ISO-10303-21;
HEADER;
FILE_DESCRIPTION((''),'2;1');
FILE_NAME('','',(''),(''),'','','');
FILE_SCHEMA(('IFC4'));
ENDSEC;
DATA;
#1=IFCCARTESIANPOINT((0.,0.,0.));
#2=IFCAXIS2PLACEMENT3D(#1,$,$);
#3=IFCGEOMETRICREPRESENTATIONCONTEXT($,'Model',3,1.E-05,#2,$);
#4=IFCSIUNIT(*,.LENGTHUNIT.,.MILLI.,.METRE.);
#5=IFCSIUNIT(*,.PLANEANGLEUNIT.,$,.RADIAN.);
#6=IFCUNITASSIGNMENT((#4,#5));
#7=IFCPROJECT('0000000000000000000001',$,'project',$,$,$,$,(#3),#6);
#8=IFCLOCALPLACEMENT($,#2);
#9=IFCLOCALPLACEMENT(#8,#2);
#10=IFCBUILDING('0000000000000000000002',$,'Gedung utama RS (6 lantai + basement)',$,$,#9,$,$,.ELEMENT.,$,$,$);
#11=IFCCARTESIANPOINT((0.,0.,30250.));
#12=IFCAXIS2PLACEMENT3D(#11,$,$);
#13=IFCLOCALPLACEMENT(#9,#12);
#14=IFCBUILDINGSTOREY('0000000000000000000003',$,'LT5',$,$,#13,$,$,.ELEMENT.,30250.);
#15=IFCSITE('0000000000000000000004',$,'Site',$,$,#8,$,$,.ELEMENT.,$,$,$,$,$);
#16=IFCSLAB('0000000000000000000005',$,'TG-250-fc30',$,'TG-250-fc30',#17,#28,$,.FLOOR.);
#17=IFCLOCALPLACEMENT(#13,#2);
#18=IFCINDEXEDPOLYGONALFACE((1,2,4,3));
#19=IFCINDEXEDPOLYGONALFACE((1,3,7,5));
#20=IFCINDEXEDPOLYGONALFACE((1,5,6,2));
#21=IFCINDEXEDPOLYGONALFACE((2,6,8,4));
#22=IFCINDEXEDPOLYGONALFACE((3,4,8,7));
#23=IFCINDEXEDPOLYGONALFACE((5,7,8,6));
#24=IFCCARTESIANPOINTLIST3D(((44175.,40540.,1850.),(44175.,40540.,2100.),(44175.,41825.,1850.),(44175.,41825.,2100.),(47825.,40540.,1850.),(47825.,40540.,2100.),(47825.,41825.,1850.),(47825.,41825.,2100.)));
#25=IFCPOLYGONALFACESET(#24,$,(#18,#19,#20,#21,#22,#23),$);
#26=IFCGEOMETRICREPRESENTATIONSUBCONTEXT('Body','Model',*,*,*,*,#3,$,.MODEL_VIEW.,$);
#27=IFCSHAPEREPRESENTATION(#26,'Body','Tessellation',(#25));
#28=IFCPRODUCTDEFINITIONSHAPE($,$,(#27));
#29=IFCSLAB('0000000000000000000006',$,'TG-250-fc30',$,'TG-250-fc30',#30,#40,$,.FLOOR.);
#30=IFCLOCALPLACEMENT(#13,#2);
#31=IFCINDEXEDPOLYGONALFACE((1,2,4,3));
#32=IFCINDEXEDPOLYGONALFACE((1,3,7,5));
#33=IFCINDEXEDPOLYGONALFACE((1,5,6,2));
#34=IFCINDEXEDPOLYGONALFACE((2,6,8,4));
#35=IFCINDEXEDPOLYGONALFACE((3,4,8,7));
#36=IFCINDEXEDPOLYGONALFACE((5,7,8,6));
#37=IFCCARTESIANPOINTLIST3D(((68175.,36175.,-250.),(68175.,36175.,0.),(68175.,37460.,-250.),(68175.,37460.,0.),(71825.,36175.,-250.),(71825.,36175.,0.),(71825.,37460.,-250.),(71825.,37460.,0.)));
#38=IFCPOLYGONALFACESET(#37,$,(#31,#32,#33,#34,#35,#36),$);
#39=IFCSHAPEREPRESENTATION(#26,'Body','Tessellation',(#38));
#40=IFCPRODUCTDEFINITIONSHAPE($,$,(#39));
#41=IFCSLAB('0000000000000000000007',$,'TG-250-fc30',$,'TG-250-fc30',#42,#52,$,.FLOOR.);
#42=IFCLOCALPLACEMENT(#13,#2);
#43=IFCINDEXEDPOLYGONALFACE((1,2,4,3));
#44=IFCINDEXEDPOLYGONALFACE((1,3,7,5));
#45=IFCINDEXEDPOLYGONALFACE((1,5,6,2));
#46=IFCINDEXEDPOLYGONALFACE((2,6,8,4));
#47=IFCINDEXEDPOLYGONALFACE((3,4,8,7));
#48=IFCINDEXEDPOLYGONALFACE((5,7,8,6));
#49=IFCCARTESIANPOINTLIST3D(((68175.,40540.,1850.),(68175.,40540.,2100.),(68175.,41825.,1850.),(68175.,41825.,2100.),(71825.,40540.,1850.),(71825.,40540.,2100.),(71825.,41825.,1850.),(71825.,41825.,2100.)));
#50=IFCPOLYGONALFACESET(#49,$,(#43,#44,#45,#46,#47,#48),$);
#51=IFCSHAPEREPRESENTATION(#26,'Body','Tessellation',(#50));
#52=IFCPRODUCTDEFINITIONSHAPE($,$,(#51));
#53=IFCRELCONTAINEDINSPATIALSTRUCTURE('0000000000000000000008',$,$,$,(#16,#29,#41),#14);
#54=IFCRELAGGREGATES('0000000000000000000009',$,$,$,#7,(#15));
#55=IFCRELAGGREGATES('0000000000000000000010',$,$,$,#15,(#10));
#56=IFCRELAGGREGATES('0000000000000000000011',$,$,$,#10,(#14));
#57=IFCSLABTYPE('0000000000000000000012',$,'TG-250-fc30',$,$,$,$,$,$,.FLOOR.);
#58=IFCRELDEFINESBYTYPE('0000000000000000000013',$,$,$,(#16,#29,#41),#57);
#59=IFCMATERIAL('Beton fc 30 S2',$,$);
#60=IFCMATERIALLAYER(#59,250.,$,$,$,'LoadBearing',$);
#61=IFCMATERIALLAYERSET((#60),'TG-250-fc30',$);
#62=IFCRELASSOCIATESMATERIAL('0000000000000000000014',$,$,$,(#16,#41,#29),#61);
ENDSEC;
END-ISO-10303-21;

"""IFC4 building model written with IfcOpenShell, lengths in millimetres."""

from ifc_helpers import new_model, si_unit, frame, origin, place, context, subcontext, project, spatial, polyline, outline, extrude, material, layer, layer_set, layer_usage, type_object, element, save


model = new_model("IFC4")

# Units and contexts
model_context = context("Model", 3, precision=1e-05, world=origin())
body_context = subcontext(model_context, "Body", "Model", "MODEL_VIEW")
ifc_project = project(units=[si_unit("LENGTHUNIT", "METRE", prefix="MILLI"), si_unit("PLANEANGLEUNIT", "RADIAN")], contexts=[model_context])

# Site, building, storey
site_placement = place(None, origin())
site = spatial("IfcSite", under=ifc_project, at=site_placement, Name="Site", CompositionType="ELEMENT")
building_placement = place(site_placement, origin())
building = spatial("IfcBuilding", under=site, at=building_placement, Name="Gedung utama RS (6 lantai + basement)", CompositionType="ELEMENT")
storey_placement = place(building_placement, frame((0.0, 0.0, 30250.0)))
storey = spatial("IfcBuildingStorey", under=building, at=storey_placement, Name="LT5", CompositionType="ELEMENT", Elevation=30250.0)

# Shared definitions
ifc_material = material(Name="Beton fc 30 S2")

# Slabs
ifc_layer_1 = layer(ifc_material, 250.0, Category="LoadBearing")
ifc_layer_set_1 = layer_set([ifc_layer_1], Name="TG-250-fc30")
ifc_layer_usage_1 = layer_usage(ifc_layer_set_1, "AXIS3", "NEGATIVE", 0.0)
slab_type_1 = type_object("IfcSlabType", Name="TG-250-fc30", PredefinedType="FLOOR")
ifc_layer_usage_2 = layer_usage(ifc_layer_set_1, "AXIS3", "NEGATIVE", 2100.0)
slab_1_placement = place(storey_placement, origin())
element("IfcSlab", 1, at=slab_1_placement, inside=storey, type_object=slab_type_1, material=ifc_layer_usage_2, Name="TG-250-fc30", ObjectType="TG-250-fc30", PredefinedType="FLOOR", context=body_context, shape_type="SweptSolid", body=[
    extrude(outline(polyline([(47825.0, 40540.0), (47825.0, 41825.0), (44175.0, 41825.0), (44175.0, 40540.0), (47825.0, 40540.0)])), frame((0.0, 0.0, 1850.0)), (0.0, 0.0, 1.0), 250.0),
])
slab_2_placement = place(storey_placement, origin())
element("IfcSlab", 2, at=slab_2_placement, inside=storey, type_object=slab_type_1, material=ifc_layer_usage_1, Name="TG-250-fc30", ObjectType="TG-250-fc30", PredefinedType="FLOOR", context=body_context, shape_type="SweptSolid", body=[
    extrude(outline(polyline([(71825.0, 36175.0), (71825.0, 37460.0), (68175.0, 37460.0), (68175.0, 36175.0), (71825.0, 36175.0)])), frame((0.0, 0.0, -250.0)), (0.0, 0.0, 1.0), 250.0),
])
slab_3_placement = place(storey_placement, origin())
element("IfcSlab", 3, at=slab_3_placement, inside=storey, type_object=slab_type_1, material=ifc_layer_usage_2, Name="TG-250-fc30", ObjectType="TG-250-fc30", PredefinedType="FLOOR", context=body_context, shape_type="SweptSolid", body=[
    extrude(outline(polyline([(71825.0, 40540.0), (71825.0, 41825.0), (68175.0, 41825.0), (68175.0, 40540.0), (71825.0, 40540.0)])), frame((0.0, 0.0, 1850.0)), (0.0, 0.0, 1.0), 250.0),
])

save(model, "model.ifc")
